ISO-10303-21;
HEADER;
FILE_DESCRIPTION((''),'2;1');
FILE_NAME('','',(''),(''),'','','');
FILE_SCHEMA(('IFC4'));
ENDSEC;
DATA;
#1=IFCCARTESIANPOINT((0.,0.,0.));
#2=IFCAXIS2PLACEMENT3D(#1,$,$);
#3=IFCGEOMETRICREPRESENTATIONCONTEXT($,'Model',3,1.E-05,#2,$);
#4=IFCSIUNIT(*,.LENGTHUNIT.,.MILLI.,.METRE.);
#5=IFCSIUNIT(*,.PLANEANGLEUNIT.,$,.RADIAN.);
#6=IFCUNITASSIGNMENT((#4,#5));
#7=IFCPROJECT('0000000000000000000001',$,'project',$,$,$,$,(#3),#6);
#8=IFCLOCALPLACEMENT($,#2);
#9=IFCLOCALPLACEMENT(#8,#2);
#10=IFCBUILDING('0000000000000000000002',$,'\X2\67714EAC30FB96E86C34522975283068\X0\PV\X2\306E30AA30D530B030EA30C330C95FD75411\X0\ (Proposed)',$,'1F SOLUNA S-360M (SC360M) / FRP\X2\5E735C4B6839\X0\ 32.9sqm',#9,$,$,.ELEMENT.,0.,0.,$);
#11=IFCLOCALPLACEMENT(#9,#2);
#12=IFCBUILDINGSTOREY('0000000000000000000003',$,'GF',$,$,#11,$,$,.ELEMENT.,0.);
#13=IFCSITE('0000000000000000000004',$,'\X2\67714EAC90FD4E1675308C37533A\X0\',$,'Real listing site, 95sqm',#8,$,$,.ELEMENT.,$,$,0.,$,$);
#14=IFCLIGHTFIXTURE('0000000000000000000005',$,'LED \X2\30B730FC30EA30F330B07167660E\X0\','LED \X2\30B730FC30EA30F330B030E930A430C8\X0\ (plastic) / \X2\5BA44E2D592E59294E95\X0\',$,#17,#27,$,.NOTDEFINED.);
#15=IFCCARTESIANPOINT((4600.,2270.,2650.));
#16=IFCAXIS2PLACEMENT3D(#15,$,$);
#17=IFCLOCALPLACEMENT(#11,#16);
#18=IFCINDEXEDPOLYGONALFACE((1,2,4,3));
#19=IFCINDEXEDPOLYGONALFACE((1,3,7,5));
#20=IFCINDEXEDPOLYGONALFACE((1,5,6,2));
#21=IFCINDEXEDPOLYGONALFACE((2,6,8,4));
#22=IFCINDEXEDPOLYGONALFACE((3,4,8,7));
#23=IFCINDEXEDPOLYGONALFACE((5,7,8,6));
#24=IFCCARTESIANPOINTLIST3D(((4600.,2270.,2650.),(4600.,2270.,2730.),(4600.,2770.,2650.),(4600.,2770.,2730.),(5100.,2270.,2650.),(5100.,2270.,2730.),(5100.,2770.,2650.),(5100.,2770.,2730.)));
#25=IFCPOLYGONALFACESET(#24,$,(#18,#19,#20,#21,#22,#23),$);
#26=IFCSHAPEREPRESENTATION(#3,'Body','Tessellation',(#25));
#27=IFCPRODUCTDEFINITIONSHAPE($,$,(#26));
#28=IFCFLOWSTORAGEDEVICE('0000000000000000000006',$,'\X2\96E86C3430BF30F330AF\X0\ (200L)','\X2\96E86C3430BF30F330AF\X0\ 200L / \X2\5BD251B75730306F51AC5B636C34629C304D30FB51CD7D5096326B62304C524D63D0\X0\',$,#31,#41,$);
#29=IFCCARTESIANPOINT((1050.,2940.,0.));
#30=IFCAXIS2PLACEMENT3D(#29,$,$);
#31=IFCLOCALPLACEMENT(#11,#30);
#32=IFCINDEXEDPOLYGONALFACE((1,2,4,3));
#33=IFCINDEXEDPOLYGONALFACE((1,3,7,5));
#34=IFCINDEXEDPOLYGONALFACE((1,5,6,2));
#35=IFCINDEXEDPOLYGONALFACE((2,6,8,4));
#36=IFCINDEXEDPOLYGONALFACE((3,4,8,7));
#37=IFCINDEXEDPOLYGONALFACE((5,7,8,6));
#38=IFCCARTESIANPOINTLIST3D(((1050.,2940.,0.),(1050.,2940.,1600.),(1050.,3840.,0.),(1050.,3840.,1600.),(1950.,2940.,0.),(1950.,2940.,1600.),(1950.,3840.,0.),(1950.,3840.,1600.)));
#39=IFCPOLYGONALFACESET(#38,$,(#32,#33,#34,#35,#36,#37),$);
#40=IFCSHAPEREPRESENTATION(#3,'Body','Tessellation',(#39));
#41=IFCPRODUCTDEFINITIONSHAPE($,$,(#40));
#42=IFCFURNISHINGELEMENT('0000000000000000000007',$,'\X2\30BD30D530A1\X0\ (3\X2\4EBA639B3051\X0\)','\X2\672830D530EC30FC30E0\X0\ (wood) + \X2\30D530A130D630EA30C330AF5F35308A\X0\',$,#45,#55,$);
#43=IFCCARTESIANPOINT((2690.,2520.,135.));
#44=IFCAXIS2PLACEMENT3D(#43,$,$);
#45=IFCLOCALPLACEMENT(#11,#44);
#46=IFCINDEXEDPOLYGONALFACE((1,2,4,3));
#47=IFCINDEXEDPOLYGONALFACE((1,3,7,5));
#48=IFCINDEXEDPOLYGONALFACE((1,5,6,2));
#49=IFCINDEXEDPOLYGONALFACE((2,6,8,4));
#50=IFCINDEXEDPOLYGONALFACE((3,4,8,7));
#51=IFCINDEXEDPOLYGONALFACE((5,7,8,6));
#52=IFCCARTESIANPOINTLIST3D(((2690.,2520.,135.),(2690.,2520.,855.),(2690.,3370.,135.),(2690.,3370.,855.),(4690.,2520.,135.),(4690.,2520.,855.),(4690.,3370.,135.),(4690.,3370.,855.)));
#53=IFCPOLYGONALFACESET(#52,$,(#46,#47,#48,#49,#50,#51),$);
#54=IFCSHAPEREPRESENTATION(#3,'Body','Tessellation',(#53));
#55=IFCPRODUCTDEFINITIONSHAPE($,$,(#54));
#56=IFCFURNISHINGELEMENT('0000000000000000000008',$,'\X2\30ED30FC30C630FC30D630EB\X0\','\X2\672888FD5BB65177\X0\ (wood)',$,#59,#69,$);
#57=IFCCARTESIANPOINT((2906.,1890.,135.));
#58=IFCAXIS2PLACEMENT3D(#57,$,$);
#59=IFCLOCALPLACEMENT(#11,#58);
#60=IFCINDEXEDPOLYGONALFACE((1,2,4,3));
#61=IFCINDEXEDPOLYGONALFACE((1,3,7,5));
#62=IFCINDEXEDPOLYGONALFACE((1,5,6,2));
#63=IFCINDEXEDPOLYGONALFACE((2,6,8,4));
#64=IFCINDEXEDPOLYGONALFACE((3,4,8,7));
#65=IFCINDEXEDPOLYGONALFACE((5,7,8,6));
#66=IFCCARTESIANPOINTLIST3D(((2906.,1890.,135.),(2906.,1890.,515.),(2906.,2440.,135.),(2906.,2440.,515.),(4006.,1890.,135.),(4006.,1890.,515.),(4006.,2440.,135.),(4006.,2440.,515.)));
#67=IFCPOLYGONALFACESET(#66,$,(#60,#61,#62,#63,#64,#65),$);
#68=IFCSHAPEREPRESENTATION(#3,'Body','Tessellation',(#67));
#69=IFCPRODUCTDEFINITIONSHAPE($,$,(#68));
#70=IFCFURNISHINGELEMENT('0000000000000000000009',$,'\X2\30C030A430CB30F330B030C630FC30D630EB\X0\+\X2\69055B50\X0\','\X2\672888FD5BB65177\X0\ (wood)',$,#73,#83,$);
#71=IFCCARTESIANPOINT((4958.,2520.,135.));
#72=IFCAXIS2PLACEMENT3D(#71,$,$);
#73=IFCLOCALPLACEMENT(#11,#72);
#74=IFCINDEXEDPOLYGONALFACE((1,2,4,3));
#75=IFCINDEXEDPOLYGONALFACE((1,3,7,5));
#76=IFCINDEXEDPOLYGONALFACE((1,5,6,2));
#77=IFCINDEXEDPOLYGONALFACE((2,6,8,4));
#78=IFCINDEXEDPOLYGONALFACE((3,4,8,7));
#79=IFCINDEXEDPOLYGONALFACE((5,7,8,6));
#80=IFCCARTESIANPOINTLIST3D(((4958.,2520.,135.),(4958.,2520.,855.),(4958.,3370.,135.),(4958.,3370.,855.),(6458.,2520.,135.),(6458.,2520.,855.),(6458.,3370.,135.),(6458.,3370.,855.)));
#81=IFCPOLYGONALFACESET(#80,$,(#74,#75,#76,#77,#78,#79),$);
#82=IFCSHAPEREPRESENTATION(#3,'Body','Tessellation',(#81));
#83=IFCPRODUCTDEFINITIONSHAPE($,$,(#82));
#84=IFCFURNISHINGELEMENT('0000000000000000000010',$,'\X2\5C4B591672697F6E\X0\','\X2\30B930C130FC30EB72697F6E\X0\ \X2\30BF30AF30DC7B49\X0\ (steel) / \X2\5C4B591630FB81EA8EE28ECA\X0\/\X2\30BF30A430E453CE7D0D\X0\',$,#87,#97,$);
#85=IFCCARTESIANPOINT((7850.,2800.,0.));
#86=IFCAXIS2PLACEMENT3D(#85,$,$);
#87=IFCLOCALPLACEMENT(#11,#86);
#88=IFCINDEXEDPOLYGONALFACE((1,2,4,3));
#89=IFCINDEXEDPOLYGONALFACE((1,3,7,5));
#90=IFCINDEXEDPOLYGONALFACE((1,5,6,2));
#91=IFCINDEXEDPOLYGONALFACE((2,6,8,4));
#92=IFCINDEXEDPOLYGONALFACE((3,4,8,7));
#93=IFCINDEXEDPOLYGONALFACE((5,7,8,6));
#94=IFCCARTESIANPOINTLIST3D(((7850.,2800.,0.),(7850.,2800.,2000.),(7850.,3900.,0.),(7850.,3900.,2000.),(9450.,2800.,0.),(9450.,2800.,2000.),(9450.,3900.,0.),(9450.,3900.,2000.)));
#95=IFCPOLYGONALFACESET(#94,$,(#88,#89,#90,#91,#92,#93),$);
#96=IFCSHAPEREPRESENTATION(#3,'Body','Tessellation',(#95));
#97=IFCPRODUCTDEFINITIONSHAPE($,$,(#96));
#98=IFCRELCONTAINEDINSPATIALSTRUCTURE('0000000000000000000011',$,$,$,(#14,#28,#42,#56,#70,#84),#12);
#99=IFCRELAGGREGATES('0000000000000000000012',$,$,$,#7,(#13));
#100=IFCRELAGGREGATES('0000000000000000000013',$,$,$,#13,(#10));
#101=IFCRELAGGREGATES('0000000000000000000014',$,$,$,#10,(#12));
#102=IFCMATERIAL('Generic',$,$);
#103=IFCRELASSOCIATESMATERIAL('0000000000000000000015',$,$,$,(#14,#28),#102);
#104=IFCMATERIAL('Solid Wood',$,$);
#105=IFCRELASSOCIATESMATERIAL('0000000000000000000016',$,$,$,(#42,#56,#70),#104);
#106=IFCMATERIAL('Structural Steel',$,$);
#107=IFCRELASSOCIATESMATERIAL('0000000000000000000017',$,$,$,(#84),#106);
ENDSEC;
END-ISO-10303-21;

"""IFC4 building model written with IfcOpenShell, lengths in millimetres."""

from ifc_helpers import new_model, si_unit, frame, frame_2d, origin, place, context, project, spatial, rectangle, extrude, material, element, save


model = new_model("IFC4")

# Units and contexts
model_context = context("Model", 3, precision=1e-05, world=origin())
ifc_project = project(units=[si_unit("LENGTHUNIT", "METRE", prefix="MILLI"), si_unit("PLANEANGLEUNIT", "RADIAN")], contexts=[model_context])

# Site, building, storey
site_placement = place(None, origin())
site = spatial("IfcSite", under=ifc_project, at=site_placement, Name="東京都世田谷区", ObjectType="Real listing site, 95sqm", CompositionType="ELEMENT", RefElevation=0.0)
building_placement = place(site_placement, origin())
building = spatial("IfcBuilding", under=site, at=building_placement, Name="東京・雨水利用とPVのオフグリッド志向 (Proposed)", ObjectType="1F SOLUNA S-360M (SC360M) / FRP平屋根 32.9sqm", CompositionType="ELEMENT", ElevationOfRefHeight=0.0, ElevationOfTerrain=0.0)
storey_placement = place(building_placement, origin())
storey = spatial("IfcBuildingStorey", under=building, at=storey_placement, Name="GF", CompositionType="ELEMENT", Elevation=0.0)

# Shared definitions
ifc_material_1 = material(Name="Solid Wood")

# Shared definitions
ifc_material_2 = material(Name="Structural Steel")

# Light fixture
ifc_material_3 = material(Name="Generic")
light_fixture_placement = place(storey_placement, frame((4600.0, 2270.0, 2650.0)))
element("IfcLightFixture", 1, at=light_fixture_placement, inside=storey, material=ifc_material_3, Name="LED シーリング照明", Description="LED シーリングライト (plastic) / 室中央天井", PredefinedType="NOTDEFINED", context=model_context, shape_type="SweptSolid", body=[
    extrude(rectangle(XDim=500.0, YDim=500.0, at=frame_2d((250.0, 250.0))), frame((4600.0, 2270.0, 2650.0)), (0.0, 0.0, 1.0), 80.0),
])

# Flow storage device
flow_storage_device_placement = place(storey_placement, frame((1050.0, 2940.0, 0.0)))
element("IfcFlowStorageDevice", 2, at=flow_storage_device_placement, inside=storey, material=ifc_material_3, Name="雨水タンク (200L)", Description="雨水タンク 200L / 寒冷地は冬季水抜き・凍結防止が前提", context=model_context, shape_type="SweptSolid", body=[
    extrude(rectangle(XDim=900.0, YDim=900.0, at=frame_2d((450.0, 450.0))), frame((1050.0, 2940.0, 0.0)), (0.0, 0.0, 1.0), 1600.0),
])

# Furnishing elements
furnishing_1_placement = place(storey_placement, frame((2690.0, 2520.0, 135.0)))
element("IfcFurnishingElement", 3, at=furnishing_1_placement, inside=storey, material=ifc_material_1, Name="ソファ (3人掛け)", Description="木フレーム (wood) + ファブリック張り", context=model_context, shape_type="SweptSolid", body=[
    extrude(rectangle(XDim=2000.0, YDim=850.0, at=frame_2d((1000.0, 425.0))), frame((2690.0, 2520.0, 135.0)), (0.0, 0.0, 1.0), 720.0),
])
furnishing_2_placement = place(storey_placement, frame((2906.0, 1890.0, 135.0)))
element("IfcFurnishingElement", 4, at=furnishing_2_placement, inside=storey, material=ifc_material_1, Name="ローテーブル", Description="木製家具 (wood)", context=model_context, shape_type="SweptSolid", body=[
    extrude(rectangle(XDim=1100.0, YDim=550.0, at=frame_2d((550.0, 275.0))), frame((2906.0, 1890.0, 135.0)), (0.0, 0.0, 1.0), 380.0),
])
furnishing_3_placement = place(storey_placement, frame((4958.0, 2520.0, 135.0)))
element("IfcFurnishingElement", 5, at=furnishing_3_placement, inside=storey, material=ifc_material_1, Name="ダイニングテーブル+椅子", Description="木製家具 (wood)", context=model_context, shape_type="SweptSolid", body=[
    extrude(rectangle(XDim=1500.0, YDim=850.0, at=frame_2d((750.0, 425.0))), frame((4958.0, 2520.0, 135.0)), (0.0, 0.0, 1.0), 720.0),
])
furnishing_4_placement = place(storey_placement, frame((7850.0, 2800.0, 0.0)))
element("IfcFurnishingElement", 6, at=furnishing_4_placement, inside=storey, material=ifc_material_2, Name="屋外物置", Description="スチール物置 タクボ等 (steel) / 屋外・自転車/タイヤ収納", context=model_context, shape_type="SweptSolid", body=[
    extrude(rectangle(XDim=1600.0, YDim=1100.0, at=frame_2d((800.0, 550.0))), frame((7850.0, 2800.0, 0.0)), (0.0, 0.0, 1.0), 2000.0),
])

save(model, "model.ifc")
